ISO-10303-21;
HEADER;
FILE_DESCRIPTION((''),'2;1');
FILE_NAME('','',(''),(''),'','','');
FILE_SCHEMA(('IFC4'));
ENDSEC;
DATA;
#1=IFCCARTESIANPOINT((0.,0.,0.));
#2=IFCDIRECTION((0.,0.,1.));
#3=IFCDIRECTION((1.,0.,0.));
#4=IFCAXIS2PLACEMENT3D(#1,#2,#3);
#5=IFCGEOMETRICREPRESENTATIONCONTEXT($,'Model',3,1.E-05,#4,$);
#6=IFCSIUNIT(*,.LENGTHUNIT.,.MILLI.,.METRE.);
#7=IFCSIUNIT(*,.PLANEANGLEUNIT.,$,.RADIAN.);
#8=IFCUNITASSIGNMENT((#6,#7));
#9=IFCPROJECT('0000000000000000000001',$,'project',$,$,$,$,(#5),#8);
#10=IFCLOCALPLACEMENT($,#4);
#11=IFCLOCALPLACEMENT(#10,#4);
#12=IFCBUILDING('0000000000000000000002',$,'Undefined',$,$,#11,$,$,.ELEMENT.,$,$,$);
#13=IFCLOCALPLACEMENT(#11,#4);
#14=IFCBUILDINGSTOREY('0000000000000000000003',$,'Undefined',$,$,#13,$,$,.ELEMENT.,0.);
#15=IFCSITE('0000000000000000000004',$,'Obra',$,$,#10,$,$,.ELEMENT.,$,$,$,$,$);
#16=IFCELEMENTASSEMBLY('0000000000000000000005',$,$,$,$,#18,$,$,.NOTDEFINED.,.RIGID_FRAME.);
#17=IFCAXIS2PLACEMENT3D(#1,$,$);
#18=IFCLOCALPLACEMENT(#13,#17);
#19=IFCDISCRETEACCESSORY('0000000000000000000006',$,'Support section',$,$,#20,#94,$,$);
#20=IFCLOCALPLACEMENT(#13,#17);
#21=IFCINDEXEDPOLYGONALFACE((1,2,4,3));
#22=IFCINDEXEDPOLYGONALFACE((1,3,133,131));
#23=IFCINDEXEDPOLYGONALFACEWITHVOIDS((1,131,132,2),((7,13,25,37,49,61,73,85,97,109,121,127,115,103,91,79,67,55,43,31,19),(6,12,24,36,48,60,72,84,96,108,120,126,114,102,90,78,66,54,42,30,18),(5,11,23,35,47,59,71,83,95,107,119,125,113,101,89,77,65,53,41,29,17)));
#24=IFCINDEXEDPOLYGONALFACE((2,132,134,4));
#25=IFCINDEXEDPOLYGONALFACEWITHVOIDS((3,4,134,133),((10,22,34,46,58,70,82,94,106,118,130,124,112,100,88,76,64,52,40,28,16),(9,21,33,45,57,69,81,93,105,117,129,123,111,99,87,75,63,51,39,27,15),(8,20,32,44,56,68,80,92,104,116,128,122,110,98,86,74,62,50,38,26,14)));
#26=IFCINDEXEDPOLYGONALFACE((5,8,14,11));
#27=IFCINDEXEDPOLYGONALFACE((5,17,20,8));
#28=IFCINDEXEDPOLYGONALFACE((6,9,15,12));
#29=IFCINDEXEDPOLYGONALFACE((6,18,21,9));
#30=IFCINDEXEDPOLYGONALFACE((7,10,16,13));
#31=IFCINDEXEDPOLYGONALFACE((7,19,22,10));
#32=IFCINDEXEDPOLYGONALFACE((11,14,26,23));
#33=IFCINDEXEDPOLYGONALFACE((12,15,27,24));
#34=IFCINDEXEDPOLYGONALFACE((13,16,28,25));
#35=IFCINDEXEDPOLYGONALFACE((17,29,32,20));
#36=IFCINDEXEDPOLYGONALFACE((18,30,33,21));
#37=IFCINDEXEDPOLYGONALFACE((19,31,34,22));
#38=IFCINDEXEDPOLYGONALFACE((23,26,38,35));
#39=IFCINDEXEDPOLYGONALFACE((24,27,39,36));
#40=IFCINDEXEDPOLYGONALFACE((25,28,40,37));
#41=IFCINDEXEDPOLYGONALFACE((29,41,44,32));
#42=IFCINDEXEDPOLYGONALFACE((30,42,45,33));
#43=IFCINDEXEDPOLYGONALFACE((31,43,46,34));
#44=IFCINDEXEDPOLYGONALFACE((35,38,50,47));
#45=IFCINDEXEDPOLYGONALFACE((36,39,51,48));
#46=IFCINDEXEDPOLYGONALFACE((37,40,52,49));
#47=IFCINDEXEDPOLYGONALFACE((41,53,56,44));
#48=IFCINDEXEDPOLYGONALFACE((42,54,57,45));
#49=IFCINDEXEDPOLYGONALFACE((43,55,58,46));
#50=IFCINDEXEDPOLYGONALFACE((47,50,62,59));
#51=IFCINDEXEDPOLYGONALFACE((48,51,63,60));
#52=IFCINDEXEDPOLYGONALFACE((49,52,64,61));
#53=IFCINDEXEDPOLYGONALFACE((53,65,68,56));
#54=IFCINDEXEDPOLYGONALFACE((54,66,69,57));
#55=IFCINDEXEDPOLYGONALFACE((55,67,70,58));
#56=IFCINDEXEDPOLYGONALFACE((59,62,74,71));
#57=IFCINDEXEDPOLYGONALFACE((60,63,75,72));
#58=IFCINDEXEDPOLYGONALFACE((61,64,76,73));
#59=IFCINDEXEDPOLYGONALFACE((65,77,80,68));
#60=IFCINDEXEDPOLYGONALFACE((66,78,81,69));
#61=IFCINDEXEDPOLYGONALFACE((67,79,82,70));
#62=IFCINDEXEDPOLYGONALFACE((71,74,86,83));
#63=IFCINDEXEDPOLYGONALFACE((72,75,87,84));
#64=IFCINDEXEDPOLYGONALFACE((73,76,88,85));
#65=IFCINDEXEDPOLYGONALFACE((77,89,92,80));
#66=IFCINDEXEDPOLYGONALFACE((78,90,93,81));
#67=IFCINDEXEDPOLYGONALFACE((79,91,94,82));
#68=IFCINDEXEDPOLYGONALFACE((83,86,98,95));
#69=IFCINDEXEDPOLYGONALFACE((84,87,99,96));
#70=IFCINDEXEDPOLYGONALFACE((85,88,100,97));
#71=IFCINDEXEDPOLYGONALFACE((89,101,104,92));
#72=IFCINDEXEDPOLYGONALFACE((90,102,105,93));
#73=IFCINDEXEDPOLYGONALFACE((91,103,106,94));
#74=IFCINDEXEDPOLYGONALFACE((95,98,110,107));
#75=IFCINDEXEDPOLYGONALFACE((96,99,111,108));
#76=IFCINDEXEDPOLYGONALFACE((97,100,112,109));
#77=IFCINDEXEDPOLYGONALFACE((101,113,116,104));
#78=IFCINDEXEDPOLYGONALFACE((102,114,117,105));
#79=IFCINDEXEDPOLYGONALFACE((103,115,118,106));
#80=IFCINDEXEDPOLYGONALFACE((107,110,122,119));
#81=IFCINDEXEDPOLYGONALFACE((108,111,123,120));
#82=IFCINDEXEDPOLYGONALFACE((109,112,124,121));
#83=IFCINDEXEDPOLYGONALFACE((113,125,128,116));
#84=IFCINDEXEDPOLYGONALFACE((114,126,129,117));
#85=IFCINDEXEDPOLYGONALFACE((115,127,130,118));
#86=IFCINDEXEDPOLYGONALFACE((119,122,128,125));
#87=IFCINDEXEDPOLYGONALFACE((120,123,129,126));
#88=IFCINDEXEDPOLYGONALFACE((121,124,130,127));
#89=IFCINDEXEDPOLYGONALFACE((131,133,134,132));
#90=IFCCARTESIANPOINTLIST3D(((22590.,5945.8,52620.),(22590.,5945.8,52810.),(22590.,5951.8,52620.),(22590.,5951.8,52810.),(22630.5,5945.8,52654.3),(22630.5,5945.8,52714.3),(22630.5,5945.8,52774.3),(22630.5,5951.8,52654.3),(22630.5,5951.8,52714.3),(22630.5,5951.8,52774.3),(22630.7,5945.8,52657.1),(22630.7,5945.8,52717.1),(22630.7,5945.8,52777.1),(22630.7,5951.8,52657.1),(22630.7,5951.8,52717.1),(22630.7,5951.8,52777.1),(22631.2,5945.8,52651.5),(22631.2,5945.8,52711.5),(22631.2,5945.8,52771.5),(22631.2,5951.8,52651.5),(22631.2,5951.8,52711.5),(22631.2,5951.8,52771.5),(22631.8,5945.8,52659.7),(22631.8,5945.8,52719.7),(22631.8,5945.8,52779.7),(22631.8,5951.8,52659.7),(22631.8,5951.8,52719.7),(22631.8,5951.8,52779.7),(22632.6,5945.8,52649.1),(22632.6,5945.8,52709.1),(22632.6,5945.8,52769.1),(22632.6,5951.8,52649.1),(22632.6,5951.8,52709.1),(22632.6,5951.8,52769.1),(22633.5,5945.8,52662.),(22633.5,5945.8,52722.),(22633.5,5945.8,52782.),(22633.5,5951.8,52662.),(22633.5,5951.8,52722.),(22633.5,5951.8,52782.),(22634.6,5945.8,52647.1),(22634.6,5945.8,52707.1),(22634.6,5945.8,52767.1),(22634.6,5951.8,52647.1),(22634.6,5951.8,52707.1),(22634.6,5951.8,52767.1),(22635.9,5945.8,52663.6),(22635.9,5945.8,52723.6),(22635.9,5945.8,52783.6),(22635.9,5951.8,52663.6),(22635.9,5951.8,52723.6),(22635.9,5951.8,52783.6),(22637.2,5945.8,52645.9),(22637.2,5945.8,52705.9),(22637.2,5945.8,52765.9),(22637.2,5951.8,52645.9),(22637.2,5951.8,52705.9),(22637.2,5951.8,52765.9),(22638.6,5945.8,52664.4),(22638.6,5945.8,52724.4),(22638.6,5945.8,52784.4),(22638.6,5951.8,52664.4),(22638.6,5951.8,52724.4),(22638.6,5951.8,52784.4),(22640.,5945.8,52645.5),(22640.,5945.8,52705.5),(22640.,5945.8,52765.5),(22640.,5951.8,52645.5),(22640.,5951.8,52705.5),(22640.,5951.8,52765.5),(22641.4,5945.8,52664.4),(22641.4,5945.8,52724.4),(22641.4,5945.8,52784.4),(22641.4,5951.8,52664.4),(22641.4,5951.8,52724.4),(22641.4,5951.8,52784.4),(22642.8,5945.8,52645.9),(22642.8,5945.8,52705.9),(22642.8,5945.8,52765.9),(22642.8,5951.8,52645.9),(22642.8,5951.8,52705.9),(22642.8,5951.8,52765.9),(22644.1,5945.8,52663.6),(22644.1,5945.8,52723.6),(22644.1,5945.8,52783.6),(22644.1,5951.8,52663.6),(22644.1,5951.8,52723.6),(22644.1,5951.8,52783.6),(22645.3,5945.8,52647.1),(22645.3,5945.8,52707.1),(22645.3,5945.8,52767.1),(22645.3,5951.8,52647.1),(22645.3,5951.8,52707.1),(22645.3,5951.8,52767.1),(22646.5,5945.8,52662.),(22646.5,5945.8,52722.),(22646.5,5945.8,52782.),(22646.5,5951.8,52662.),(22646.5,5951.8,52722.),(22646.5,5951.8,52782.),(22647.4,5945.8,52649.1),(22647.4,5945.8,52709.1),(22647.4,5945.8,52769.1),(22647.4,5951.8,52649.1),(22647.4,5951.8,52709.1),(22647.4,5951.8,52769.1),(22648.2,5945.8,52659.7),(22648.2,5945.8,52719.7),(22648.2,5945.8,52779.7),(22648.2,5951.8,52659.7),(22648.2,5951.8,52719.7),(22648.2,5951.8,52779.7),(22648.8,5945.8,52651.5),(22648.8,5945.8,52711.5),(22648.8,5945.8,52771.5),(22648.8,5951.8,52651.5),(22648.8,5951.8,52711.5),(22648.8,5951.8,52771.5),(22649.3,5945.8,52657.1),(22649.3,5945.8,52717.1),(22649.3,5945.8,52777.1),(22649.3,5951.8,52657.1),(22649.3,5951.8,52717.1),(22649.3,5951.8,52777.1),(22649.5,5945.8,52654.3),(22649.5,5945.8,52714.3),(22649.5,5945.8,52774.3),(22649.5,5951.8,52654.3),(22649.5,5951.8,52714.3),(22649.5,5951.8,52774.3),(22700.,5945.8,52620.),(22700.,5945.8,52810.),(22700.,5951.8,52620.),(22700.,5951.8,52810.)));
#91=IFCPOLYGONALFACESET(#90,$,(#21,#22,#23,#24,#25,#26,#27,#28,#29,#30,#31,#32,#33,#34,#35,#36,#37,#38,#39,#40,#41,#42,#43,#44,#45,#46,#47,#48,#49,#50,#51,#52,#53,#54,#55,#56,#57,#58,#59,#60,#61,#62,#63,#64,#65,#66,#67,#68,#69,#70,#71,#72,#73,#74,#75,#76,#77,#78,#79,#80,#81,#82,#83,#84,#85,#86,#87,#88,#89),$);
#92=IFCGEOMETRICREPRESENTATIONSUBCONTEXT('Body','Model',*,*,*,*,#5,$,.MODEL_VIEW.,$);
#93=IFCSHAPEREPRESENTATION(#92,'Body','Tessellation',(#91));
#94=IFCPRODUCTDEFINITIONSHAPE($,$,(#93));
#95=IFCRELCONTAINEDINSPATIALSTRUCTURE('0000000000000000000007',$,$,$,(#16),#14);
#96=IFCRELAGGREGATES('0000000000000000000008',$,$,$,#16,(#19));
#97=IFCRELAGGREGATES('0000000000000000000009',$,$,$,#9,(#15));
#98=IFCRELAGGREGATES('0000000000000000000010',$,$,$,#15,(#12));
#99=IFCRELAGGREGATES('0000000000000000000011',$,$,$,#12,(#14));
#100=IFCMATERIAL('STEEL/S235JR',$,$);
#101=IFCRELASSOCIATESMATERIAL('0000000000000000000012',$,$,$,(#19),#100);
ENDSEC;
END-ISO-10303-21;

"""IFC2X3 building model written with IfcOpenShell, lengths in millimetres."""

from ifc_helpers import new_model, si_unit, frame, origin_with_axes, origin_2d_with_axis, place, context, subcontext, project, spatial, rectangle, circle, extrude, source, transform, mapped, material, element, aggregate, save


model = new_model("IFC2X3")

# Units and contexts
model_context = context("Model", 3, precision=1e-05, world=origin_with_axes())
body_context = subcontext(model_context, "Body", "Model", "MODEL_VIEW")
ifc_project = project(units=[si_unit("LENGTHUNIT", "METRE", prefix="MILLI"), si_unit("PLANEANGLEUNIT", "RADIAN")], contexts=[model_context])

# Site, building, storey
site_placement = place(None, origin_with_axes())
site = spatial("IfcSite", under=ifc_project, at=site_placement, Name="Obra", CompositionType="ELEMENT")
building_placement = place(site_placement, origin_with_axes())
building = spatial("IfcBuilding", under=site, at=building_placement, Name="Undefined", CompositionType="ELEMENT")
storey_placement = place(building_placement, origin_with_axes())
storey = spatial("IfcBuildingStorey", under=building, at=storey_placement, Name="Undefined", CompositionType="ELEMENT", Elevation=0.0)

# Element assembly
assembly_1_placement = place(storey_placement, origin_with_axes())
assembly_1 = element("IfcElementAssembly", 1, at=assembly_1_placement, inside=storey, AssemblyPlace="NOTDEFINED", PredefinedType="RIGID_FRAME")
ifc_material_1 = material(Name="STEEL/S235JR")

# Discrete accessory, opening
discrete_accessory_placement = place(assembly_1_placement, frame((22645.0, 5948.8, 52620.0), z_axis=(0.0, 0.0, 1.0), x_axis=(1.0, 0.0, 0.0)))
discrete_accessory = element("IfcDiscreteAccessory", 2, at=discrete_accessory_placement, material=ifc_material_1, Name="Support section", context=body_context, shape_type="SweptSolid", body=[
    extrude(rectangle(XDim=6.0, YDim=110.0, at=origin_2d_with_axis()), frame((0.0, 0.0, 190.0), z_axis=(0.0, 0.0, -1.0), x_axis=(0.0, 1.0, 0.0)), (0.0, 0.0, 1.0), 190.0),
])
shared_shape_1 = source(origin_with_axes(), body_context, "Body", "SweptSolid", [
    extrude(circle(Radius=9.5, at=origin_2d_with_axis()), frame((0.0, -9.2, 0.0), z_axis=(0.0, 1.0, 0.0), x_axis=(1.0, 0.0, 0.0)), (0.0, 0.0, 1.0), 6.2),
])
opening_1_placement = place(assembly_1_placement, frame((22690.0, 5942.7, 52835.0), z_axis=(-1.0, 0.0, 0.0), x_axis=(0.0, 0.0, -1.0)))
element("IfcOpeningElement", 3, at=opening_1_placement, cuts=discrete_accessory, ObjectType="Opening", context=body_context, shape_type="MappedRepresentation", body=[
    mapped(shared_shape_1, transform((60.0, 0.0, 50.0))),
    mapped(shared_shape_1, transform((120.0, 0.0, 50.0))),
    mapped(shared_shape_1, transform((180.0, 0.0, 50.0))),
])
aggregate(assembly_1, [discrete_accessory])

save(model, "model.ifc")
